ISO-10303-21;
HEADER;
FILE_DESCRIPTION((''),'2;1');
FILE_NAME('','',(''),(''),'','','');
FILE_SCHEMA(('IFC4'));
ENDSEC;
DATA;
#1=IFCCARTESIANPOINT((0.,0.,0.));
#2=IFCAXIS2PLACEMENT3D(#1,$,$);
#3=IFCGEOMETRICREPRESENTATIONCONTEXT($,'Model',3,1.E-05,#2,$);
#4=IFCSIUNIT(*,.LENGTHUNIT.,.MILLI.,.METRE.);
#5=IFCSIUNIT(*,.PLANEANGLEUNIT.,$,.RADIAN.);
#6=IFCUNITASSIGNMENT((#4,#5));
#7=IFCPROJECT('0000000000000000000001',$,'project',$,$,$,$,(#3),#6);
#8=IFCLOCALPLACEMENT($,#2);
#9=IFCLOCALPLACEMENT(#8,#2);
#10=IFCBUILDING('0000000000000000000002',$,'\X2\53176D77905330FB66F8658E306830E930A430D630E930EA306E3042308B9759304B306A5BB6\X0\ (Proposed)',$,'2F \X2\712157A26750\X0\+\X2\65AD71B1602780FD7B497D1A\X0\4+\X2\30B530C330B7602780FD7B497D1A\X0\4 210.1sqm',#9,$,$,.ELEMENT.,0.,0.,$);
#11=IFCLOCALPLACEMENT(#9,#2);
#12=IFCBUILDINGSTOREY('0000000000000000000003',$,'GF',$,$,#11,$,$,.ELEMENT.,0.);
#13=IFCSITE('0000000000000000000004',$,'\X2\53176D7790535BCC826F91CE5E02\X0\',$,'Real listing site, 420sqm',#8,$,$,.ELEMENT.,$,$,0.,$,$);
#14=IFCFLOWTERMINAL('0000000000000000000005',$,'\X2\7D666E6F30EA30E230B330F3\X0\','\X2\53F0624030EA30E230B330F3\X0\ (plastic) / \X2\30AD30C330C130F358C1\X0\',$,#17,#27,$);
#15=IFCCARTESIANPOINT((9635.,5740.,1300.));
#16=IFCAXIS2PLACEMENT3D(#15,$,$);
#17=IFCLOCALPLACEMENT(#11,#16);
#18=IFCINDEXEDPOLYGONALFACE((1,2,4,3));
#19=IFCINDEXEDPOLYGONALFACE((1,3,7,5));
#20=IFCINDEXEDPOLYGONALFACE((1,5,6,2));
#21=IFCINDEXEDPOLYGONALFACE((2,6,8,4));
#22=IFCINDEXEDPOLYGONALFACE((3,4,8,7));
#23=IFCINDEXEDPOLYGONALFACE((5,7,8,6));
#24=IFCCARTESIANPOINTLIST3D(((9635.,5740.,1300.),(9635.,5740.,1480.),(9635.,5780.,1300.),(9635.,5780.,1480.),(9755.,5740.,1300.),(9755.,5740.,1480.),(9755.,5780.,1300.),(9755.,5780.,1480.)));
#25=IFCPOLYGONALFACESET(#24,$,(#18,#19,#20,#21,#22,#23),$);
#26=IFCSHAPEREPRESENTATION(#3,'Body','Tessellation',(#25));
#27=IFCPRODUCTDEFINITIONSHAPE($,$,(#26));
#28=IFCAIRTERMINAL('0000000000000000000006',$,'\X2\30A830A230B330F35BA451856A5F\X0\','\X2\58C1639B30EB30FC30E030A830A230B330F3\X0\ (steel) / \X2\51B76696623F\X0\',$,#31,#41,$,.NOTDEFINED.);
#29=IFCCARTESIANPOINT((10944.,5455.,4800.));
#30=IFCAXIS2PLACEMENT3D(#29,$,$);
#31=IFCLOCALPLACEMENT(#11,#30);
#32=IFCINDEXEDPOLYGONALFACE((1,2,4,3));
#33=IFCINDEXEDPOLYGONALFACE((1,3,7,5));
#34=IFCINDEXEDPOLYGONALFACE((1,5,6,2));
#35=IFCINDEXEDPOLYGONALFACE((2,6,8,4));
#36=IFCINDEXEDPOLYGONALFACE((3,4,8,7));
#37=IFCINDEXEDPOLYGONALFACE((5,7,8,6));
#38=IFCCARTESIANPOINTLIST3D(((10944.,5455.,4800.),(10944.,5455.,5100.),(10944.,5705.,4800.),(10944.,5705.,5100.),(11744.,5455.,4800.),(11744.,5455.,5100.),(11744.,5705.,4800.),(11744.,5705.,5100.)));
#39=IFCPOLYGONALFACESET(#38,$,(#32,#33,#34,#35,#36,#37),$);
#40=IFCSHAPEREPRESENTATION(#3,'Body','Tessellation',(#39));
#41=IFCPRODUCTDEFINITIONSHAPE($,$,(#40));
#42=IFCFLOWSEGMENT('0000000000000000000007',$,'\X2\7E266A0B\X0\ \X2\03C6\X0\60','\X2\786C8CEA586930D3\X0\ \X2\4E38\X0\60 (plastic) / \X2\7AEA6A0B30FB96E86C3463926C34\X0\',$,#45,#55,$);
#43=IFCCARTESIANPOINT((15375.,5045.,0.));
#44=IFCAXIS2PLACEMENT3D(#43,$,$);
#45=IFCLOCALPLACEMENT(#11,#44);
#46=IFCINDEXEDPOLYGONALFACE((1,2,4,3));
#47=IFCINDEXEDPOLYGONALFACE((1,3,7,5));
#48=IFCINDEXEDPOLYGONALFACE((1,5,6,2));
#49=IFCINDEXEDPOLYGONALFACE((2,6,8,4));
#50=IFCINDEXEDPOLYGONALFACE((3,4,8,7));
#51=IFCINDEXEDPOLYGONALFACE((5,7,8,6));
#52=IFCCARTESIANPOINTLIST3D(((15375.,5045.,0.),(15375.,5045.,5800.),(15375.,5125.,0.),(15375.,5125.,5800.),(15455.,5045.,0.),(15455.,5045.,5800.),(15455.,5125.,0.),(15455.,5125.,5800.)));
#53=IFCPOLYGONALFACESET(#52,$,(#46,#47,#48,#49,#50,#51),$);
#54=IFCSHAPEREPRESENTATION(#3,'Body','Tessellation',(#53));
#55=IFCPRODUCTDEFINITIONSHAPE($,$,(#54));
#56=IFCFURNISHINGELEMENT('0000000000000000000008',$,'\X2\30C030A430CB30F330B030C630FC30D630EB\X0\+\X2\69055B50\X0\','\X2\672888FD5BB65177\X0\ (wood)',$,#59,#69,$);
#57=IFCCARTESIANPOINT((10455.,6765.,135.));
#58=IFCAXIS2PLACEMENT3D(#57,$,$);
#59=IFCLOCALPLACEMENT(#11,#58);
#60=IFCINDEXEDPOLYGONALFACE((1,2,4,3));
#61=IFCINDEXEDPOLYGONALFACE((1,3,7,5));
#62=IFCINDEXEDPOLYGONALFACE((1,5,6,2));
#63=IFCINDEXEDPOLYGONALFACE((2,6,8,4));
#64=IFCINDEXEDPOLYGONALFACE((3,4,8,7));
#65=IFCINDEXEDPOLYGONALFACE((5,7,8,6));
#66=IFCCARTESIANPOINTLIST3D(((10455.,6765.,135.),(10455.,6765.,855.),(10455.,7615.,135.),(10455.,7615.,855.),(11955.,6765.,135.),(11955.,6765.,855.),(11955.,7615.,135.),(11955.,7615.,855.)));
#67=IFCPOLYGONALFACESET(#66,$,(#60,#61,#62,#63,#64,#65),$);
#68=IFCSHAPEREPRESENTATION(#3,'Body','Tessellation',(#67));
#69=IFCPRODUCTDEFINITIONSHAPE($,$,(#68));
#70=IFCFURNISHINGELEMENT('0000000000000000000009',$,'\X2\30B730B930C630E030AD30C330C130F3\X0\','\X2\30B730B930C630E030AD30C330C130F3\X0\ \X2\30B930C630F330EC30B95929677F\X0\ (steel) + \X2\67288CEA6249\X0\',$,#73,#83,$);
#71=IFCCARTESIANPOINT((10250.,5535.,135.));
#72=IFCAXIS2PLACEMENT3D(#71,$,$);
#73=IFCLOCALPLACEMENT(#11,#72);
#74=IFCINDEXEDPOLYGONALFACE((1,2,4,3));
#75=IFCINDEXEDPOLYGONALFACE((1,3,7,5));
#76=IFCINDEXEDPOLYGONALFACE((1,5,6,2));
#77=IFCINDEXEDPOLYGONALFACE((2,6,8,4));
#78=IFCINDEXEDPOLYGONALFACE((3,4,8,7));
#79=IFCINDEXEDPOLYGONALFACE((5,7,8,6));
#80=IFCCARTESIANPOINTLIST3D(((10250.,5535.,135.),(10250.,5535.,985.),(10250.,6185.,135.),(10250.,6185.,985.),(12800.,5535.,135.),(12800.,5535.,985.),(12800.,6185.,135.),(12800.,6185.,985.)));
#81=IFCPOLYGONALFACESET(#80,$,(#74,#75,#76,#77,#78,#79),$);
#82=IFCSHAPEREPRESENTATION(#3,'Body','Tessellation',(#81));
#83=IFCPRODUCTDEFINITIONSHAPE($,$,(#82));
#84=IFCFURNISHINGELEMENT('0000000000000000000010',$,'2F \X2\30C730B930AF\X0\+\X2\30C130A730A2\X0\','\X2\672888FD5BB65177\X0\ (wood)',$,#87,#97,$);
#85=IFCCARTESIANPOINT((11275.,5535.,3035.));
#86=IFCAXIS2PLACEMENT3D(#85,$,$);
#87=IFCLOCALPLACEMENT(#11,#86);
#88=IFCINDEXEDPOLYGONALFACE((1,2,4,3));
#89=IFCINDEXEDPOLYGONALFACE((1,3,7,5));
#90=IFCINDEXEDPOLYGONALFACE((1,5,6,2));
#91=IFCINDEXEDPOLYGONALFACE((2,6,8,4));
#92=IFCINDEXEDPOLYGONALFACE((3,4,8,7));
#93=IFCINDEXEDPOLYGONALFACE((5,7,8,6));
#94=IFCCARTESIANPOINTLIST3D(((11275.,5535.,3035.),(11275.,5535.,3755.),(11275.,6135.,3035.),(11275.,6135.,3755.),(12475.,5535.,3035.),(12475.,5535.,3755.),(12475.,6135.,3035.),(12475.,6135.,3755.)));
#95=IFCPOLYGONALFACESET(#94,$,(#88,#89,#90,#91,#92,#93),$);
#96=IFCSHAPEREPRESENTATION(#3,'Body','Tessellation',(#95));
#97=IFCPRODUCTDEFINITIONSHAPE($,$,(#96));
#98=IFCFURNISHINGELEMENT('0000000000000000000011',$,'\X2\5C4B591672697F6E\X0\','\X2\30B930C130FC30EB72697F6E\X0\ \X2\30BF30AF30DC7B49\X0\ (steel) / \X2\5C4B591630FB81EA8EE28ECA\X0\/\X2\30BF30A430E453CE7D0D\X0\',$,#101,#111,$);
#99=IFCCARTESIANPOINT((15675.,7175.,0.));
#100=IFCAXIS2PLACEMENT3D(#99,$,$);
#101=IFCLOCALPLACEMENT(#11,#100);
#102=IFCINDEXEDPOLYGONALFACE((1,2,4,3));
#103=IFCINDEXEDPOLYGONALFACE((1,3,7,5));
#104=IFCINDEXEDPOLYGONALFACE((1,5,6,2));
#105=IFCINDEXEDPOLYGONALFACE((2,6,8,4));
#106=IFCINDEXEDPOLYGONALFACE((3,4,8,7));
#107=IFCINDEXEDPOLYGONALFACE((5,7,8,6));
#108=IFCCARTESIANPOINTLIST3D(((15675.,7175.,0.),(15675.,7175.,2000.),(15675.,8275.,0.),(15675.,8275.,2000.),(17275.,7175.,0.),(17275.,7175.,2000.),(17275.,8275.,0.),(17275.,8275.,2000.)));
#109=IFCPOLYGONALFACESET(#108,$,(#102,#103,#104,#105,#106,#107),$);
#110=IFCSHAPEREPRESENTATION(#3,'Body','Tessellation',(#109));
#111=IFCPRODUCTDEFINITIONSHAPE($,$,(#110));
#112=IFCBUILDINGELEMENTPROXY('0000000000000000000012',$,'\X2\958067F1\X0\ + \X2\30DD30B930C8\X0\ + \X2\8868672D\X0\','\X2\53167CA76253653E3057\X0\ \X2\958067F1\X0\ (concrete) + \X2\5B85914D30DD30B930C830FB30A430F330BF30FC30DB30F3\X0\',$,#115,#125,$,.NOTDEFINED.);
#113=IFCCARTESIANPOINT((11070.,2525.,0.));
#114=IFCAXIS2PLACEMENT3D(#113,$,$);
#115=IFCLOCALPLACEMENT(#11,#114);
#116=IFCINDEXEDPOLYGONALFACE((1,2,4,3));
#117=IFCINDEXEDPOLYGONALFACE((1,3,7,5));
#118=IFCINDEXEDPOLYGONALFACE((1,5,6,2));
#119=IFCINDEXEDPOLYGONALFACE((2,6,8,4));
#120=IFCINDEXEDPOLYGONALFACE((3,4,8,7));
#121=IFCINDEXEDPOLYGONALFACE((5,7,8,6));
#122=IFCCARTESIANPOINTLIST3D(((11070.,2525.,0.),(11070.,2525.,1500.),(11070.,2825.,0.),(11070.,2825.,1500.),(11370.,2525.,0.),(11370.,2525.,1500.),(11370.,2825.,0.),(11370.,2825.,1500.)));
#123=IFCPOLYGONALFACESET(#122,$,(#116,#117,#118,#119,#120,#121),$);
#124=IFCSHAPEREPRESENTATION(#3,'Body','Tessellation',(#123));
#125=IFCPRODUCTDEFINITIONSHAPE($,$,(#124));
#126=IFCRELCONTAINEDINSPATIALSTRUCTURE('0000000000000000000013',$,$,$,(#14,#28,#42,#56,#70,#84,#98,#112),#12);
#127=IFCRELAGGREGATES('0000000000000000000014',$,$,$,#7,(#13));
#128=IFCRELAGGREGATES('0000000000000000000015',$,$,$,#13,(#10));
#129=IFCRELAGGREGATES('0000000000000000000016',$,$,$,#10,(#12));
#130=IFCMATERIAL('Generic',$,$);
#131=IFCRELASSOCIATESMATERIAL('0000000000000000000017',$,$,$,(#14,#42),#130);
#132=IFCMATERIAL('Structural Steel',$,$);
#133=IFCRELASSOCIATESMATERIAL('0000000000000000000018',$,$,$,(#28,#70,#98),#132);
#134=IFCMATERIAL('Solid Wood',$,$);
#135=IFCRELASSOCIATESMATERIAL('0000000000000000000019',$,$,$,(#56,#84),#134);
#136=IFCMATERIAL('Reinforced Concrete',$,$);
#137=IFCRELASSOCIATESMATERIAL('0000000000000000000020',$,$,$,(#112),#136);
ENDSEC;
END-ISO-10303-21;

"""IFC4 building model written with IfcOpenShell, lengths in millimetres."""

from ifc_helpers import new_model, si_unit, frame, frame_2d, origin, place, context, project, spatial, rectangle, extrude, material, element, save


model = new_model("IFC4")

# Units and contexts
model_context = context("Model", 3, precision=1e-05, world=origin())
ifc_project = project(units=[si_unit("LENGTHUNIT", "METRE", prefix="MILLI"), si_unit("PLANEANGLEUNIT", "RADIAN")], contexts=[model_context])

# Site, building, storey
site_placement = place(None, origin())
site = spatial("IfcSite", under=ifc_project, at=site_placement, Name="北海道富良野市", ObjectType="Real listing site, 420sqm", CompositionType="ELEMENT", RefElevation=0.0)
building_placement = place(site_placement, origin())
building = spatial("IfcBuilding", under=site, at=building_placement, Name="北海道・書斎とライブラリのある静かな家 (Proposed)", ObjectType="2F 無垢材+断熱性能等級4+サッシ性能等級4 210.1sqm", CompositionType="ELEMENT", ElevationOfRefHeight=0.0, ElevationOfTerrain=0.0)
storey_placement = place(building_placement, origin())
storey = spatial("IfcBuildingStorey", under=building, at=storey_placement, Name="GF", CompositionType="ELEMENT", Elevation=0.0)

# Shared definitions
ifc_material_1 = material(Name="Solid Wood")

# Shared definitions
ifc_material_2 = material(Name="Reinforced Concrete")

# Shared definitions
ifc_material_3 = material(Name="Structural Steel")

# Flow terminal
ifc_material_4 = material(Name="Generic")
flow_terminal_1_placement = place(storey_placement, frame((9635.0, 5740.0, 1300.0)))
element("IfcFlowTerminal", 1, at=flow_terminal_1_placement, inside=storey, material=ifc_material_4, Name="給湯リモコン", Description="台所リモコン (plastic) / キッチン壁", context=model_context, shape_type="SweptSolid", body=[
    extrude(rectangle(XDim=120.0, YDim=40.0, at=frame_2d((60.0, 20.0))), frame((9635.0, 5740.0, 1300.0)), (0.0, 0.0, 1.0), 180.0),
])

# Air terminal
air_terminal_placement = place(storey_placement, frame((10944.0, 5455.0, 4800.0)))
element("IfcAirTerminal", 2, at=air_terminal_placement, inside=storey, material=ifc_material_3, Name="エアコン室内機", Description="壁掛ルームエアコン (steel) / 冷暖房", PredefinedType="NOTDEFINED", context=model_context, shape_type="SweptSolid", body=[
    extrude(rectangle(XDim=800.0, YDim=250.0, at=frame_2d((400.0, 125.0))), frame((10944.0, 5455.0, 4800.0)), (0.0, 0.0, 1.0), 300.0),
])

# Flow segment
flow_segment_placement = place(storey_placement, frame((15375.0, 5045.0, 0.0)))
element("IfcFlowSegment", 3, at=flow_segment_placement, inside=storey, material=ifc_material_4, Name="縦樋 φ60", Description="硬質塩ビ 丸60 (plastic) / 竪樋・雨水排水", context=model_context, shape_type="SweptSolid", body=[
    extrude(rectangle(XDim=80.0, YDim=80.0, at=frame_2d((40.0, 40.0))), frame((15375.0, 5045.0, 0.0)), (0.0, 0.0, 1.0), 5800.0),
])

# Furnishing elements
furnishing_1_placement = place(storey_placement, frame((10455.0, 6765.0, 135.0)))
element("IfcFurnishingElement", 4, at=furnishing_1_placement, inside=storey, material=ifc_material_1, Name="ダイニングテーブル+椅子", Description="木製家具 (wood)", context=model_context, shape_type="SweptSolid", body=[
    extrude(rectangle(XDim=1500.0, YDim=850.0, at=frame_2d((750.0, 425.0))), frame((10455.0, 6765.0, 135.0)), (0.0, 0.0, 1.0), 720.0),
])
furnishing_2_placement = place(storey_placement, frame((10250.0, 5535.0, 135.0)))
element("IfcFurnishingElement", 5, at=furnishing_2_placement, inside=storey, material=ifc_material_3, Name="システムキッチン", Description="システムキッチン ステンレス天板 (steel) + 木質扉", context=model_context, shape_type="SweptSolid", body=[
    extrude(rectangle(XDim=2550.0, YDim=650.0, at=frame_2d((1275.0, 325.0))), frame((10250.0, 5535.0, 135.0)), (0.0, 0.0, 1.0), 850.0),
])
furnishing_3_placement = place(storey_placement, frame((11275.0, 5535.0, 3035.0)))
element("IfcFurnishingElement", 6, at=furnishing_3_placement, inside=storey, material=ifc_material_1, Name="2F デスク+チェア", Description="木製家具 (wood)", context=model_context, shape_type="SweptSolid", body=[
    extrude(rectangle(XDim=1200.0, YDim=600.0, at=frame_2d((600.0, 300.0))), frame((11275.0, 5535.0, 3035.0)), (0.0, 0.0, 1.0), 720.0),
])
furnishing_4_placement = place(storey_placement, frame((15675.0, 7175.0, 0.0)))
element("IfcFurnishingElement", 7, at=furnishing_4_placement, inside=storey, material=ifc_material_3, Name="屋外物置", Description="スチール物置 タクボ等 (steel) / 屋外・自転車/タイヤ収納", context=model_context, shape_type="SweptSolid", body=[
    extrude(rectangle(XDim=1600.0, YDim=1100.0, at=frame_2d((800.0, 550.0))), frame((15675.0, 7175.0, 0.0)), (0.0, 0.0, 1.0), 2000.0),
])

# Building element proxy
proxy_placement = place(storey_placement, frame((11070.0, 2525.0, 0.0)))
element("IfcBuildingElementProxy", 8, at=proxy_placement, inside=storey, material=ifc_material_2, Name="門柱 + ポスト + 表札", Description="化粧打放し 門柱 (concrete) + 宅配ポスト・インターホン", PredefinedType="NOTDEFINED", context=model_context, shape_type="SweptSolid", body=[
    extrude(rectangle(XDim=300.0, YDim=300.0, at=frame_2d((150.0, 150.0))), frame((11070.0, 2525.0, 0.0)), (0.0, 0.0, 1.0), 1500.0),
])

save(model, "model.ifc")
